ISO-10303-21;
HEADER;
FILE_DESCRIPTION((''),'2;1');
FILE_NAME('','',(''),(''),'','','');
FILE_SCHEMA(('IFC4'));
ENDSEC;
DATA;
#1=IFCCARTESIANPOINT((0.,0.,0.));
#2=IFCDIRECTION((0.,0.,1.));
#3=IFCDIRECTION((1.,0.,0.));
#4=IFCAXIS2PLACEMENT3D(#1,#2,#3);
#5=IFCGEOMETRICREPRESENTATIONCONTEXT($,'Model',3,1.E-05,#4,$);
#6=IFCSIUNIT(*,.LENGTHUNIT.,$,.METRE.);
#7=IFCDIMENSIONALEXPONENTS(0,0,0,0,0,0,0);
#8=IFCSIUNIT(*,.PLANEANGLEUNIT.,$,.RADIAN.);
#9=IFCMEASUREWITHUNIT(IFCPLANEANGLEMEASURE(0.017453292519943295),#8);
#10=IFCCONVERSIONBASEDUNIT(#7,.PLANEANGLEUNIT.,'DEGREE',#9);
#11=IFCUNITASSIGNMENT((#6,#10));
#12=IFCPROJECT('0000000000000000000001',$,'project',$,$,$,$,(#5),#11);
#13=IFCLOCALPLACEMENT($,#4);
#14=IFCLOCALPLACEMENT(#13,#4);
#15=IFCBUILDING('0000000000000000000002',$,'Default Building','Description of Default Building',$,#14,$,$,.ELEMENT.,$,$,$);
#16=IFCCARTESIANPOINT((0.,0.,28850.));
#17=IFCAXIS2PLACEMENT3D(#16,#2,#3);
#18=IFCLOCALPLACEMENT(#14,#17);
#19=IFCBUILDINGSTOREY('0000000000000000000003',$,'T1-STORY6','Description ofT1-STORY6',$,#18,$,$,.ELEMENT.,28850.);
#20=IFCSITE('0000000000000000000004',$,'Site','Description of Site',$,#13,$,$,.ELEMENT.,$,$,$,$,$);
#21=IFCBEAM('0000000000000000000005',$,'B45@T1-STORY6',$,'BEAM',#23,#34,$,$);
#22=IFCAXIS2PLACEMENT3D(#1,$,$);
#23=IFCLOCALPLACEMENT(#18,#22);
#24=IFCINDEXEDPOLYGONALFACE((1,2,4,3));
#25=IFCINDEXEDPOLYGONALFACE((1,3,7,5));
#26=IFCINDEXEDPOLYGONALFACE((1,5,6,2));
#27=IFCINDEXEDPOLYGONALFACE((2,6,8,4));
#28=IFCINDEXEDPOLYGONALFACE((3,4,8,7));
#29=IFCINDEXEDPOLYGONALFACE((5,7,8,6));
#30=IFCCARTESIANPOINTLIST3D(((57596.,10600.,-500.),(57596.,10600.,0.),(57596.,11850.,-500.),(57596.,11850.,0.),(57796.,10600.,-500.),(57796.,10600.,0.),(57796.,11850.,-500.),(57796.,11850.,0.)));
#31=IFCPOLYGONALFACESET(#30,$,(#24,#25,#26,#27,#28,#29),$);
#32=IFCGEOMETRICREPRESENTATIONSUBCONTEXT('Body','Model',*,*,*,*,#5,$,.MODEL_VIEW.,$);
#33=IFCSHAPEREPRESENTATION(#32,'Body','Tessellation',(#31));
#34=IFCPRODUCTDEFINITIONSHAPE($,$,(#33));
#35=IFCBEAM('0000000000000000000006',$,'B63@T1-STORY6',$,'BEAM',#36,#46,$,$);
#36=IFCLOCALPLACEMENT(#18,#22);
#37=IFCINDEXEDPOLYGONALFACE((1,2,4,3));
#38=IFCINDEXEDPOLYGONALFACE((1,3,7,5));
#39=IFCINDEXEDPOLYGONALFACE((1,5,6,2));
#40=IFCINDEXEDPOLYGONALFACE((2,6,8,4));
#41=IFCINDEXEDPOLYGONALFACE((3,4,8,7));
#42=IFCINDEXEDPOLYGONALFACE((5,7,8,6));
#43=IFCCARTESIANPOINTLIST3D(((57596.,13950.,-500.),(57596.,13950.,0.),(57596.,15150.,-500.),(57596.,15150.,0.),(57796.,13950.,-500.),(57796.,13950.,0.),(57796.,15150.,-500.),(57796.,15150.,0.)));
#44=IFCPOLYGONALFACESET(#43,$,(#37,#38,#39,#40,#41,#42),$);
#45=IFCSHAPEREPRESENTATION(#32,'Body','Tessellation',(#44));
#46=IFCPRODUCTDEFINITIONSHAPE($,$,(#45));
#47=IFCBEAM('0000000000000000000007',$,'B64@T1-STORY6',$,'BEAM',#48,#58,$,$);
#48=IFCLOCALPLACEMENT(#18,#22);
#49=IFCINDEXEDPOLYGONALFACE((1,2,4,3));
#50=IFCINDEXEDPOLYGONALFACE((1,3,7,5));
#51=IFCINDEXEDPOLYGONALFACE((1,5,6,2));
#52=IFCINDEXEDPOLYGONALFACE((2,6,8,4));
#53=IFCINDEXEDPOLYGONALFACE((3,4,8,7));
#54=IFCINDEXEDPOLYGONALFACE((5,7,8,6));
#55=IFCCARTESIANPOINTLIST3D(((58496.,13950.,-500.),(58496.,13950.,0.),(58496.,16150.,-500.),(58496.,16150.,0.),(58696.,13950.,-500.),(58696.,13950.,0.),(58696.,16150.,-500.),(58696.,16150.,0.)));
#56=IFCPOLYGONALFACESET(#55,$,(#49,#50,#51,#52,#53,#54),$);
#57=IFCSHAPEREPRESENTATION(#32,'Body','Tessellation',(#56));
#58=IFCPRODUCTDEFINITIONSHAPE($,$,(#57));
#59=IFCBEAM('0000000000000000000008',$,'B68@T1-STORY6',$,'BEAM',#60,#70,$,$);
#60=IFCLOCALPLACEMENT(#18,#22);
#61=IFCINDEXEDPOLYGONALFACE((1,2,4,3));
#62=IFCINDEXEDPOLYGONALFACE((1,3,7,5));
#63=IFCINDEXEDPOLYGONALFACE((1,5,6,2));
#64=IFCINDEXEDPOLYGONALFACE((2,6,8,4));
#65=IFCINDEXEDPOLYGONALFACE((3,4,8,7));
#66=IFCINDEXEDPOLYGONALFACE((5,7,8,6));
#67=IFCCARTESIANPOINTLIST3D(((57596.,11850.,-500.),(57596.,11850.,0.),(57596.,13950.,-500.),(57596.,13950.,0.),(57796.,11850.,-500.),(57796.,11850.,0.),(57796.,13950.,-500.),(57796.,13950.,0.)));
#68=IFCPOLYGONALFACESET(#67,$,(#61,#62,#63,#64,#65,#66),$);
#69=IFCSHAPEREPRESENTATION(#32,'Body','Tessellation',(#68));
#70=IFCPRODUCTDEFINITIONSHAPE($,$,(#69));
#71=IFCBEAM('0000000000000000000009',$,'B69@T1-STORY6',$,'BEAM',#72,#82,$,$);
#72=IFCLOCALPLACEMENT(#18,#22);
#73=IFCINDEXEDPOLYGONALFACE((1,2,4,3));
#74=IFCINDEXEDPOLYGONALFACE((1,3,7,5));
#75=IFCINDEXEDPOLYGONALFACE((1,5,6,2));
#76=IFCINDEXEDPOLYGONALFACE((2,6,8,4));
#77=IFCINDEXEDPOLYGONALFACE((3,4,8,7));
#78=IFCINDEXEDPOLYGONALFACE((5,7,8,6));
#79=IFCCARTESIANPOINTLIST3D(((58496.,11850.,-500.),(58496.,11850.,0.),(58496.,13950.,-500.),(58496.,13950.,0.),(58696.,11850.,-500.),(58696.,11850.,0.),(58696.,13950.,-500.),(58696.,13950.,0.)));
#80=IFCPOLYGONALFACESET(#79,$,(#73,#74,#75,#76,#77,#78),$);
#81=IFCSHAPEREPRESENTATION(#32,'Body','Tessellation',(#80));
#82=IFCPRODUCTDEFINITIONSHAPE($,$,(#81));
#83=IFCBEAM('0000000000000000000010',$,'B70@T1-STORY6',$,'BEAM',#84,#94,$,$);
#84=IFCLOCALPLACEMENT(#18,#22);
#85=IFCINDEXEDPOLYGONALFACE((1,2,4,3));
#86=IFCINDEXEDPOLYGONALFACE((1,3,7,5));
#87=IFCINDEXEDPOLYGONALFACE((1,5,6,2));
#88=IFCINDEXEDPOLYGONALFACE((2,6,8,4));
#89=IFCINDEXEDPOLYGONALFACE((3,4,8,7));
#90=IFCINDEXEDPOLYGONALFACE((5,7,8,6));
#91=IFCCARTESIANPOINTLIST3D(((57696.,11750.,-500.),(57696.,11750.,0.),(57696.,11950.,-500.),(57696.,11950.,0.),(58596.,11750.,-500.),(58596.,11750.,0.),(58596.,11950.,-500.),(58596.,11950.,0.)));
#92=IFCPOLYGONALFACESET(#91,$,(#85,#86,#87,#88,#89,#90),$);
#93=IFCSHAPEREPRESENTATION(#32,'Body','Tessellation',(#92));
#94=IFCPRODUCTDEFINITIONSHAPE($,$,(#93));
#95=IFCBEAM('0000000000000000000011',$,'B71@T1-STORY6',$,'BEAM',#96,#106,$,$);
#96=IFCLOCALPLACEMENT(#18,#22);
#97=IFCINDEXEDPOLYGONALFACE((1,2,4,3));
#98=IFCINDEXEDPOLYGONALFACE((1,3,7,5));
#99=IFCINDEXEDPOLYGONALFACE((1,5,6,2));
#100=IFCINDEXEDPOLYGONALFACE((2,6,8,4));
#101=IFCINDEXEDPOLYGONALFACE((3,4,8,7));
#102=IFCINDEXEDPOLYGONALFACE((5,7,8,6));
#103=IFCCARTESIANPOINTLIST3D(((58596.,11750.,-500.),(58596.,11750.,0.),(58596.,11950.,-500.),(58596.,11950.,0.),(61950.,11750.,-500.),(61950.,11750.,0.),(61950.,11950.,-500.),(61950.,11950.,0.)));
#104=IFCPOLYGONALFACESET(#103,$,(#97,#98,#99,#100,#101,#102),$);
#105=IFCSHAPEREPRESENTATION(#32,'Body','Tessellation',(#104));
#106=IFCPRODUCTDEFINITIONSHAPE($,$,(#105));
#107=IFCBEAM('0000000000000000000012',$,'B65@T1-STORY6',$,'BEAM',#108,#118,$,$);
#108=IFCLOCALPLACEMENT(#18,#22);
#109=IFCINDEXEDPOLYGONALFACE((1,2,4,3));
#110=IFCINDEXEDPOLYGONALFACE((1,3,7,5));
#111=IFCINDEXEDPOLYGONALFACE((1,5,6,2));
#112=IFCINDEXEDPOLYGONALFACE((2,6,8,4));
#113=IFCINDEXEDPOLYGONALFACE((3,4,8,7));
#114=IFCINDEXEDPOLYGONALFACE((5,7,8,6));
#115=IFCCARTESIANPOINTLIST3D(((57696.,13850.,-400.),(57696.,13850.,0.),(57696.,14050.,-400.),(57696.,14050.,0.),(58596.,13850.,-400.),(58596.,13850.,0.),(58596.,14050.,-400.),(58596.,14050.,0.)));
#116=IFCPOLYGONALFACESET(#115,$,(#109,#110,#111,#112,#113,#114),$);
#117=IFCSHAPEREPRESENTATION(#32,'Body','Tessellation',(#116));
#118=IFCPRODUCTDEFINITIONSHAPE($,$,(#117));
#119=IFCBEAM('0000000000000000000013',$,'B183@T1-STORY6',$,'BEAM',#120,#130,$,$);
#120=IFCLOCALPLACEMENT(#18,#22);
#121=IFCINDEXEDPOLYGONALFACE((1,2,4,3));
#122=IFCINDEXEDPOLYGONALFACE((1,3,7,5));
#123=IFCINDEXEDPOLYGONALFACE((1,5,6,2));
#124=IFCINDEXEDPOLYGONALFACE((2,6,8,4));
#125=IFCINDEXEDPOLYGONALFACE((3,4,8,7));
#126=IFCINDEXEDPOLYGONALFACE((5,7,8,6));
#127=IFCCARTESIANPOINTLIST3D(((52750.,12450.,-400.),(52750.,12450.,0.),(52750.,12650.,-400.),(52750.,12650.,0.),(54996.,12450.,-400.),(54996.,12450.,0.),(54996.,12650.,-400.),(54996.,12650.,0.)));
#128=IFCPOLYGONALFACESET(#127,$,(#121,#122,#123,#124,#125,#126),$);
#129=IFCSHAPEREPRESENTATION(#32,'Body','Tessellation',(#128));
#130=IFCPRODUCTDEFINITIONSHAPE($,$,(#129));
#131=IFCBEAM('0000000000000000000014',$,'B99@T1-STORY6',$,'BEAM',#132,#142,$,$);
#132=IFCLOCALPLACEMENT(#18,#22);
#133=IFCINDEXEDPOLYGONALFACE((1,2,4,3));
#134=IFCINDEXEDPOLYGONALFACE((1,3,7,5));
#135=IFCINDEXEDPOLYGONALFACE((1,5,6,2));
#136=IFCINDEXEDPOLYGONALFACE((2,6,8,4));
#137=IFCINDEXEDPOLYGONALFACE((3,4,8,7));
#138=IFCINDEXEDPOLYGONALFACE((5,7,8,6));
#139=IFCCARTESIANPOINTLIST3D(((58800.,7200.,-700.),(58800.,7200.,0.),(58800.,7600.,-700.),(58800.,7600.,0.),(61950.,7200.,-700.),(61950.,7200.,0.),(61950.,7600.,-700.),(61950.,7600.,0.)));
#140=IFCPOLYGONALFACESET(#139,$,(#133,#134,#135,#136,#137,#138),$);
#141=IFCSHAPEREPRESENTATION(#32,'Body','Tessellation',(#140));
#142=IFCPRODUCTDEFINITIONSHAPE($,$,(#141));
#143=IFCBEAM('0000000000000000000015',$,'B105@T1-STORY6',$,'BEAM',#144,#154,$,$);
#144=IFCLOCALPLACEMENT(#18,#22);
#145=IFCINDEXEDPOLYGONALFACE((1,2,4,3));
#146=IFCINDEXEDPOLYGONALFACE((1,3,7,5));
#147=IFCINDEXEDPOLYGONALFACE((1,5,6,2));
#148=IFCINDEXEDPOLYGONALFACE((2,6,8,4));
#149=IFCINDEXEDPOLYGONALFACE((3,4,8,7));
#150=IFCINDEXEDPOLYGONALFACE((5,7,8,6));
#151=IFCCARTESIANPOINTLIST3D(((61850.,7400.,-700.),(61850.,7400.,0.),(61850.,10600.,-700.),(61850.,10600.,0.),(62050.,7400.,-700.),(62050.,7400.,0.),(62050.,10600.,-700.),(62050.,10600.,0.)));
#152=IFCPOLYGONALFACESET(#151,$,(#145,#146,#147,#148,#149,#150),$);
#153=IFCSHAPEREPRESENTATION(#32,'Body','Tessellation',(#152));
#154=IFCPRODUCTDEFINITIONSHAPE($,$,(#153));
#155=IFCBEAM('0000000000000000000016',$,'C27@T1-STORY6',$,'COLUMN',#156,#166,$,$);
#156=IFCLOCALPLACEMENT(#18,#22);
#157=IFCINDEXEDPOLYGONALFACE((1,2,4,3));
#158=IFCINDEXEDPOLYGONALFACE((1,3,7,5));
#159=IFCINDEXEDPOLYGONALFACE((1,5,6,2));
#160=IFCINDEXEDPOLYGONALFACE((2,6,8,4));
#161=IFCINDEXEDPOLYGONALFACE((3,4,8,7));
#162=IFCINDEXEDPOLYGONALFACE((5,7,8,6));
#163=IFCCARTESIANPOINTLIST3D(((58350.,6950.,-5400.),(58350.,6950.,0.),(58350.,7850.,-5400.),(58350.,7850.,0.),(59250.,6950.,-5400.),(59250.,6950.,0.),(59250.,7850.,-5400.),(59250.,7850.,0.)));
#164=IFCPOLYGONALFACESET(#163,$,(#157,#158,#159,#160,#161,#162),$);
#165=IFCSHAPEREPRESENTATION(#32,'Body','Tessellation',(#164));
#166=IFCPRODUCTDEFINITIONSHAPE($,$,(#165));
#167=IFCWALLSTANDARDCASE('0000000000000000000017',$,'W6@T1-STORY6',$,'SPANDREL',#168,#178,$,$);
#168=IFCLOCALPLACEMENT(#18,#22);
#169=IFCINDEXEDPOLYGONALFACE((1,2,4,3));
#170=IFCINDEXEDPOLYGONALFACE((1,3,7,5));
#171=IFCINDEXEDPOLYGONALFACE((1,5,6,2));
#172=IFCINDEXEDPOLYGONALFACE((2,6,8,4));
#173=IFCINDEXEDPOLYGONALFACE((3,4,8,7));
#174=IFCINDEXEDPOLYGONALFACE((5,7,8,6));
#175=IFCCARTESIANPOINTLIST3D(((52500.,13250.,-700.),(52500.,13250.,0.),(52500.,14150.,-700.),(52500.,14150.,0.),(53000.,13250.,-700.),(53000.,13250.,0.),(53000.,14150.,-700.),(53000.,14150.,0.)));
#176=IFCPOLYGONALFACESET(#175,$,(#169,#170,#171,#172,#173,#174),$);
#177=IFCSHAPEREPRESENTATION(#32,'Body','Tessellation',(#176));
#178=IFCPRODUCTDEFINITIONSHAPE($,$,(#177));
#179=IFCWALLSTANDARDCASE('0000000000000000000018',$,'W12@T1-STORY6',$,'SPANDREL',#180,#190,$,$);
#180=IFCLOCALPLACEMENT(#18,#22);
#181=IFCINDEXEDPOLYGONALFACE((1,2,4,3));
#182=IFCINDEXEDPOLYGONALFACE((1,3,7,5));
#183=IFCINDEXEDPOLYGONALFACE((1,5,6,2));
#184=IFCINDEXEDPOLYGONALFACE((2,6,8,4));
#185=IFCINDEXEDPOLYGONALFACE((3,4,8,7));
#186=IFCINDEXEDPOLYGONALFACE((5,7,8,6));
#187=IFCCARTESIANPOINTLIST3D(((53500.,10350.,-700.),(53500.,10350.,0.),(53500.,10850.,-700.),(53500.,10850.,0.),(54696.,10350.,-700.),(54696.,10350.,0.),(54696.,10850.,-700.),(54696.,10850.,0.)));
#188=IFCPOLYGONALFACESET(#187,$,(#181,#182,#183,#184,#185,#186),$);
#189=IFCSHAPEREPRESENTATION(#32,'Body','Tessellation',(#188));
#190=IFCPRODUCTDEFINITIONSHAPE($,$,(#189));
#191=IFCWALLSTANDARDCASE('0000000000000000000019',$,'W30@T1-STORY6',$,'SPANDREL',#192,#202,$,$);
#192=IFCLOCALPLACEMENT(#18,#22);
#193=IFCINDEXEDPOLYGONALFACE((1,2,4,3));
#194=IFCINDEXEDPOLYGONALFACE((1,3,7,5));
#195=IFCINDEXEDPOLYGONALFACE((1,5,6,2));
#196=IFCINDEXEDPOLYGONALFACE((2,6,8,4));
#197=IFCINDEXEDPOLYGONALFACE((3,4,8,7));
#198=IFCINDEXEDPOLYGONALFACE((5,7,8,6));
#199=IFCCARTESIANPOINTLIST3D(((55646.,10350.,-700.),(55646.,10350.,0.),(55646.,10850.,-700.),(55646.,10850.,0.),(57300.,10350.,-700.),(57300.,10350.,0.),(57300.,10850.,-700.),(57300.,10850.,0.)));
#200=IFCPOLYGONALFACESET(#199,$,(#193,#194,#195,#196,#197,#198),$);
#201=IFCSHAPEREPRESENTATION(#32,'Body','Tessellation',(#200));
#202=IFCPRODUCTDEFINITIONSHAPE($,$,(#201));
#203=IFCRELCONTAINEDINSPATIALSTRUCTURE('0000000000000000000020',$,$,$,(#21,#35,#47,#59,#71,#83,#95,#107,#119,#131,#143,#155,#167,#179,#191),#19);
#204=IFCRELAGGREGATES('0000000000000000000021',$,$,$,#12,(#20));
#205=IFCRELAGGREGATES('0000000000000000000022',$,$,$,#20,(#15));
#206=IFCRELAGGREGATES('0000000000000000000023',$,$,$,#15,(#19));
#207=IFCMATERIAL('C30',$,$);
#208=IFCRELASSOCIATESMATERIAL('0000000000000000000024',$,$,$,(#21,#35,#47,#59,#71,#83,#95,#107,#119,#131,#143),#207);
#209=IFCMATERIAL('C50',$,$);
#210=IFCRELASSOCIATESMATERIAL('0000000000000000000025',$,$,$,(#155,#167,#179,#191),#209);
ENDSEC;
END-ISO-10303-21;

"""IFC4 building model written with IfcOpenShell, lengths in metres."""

from ifc_helpers import new_model, entity, si_unit, converted_unit, frame, origin_with_axes, place, context, subcontext, project, spatial, indexed_curve, rectangle, outline, extrude, material, element, save


model = new_model("IFC4")

# Units and contexts
model_context = context("Model", 3, precision=1e-05, world=origin_with_axes())
body_context = subcontext(model_context, "Body", "Model", "MODEL_VIEW")
ifc_project = project(units=[si_unit("LENGTHUNIT", "METRE"), converted_unit("PLANEANGLEUNIT", "DEGREE", entity("IfcPlaneAngleMeasure", 0.017453292519943295), si_unit("PLANEANGLEUNIT", "RADIAN"), dimensions=[0, 0, 0, 0, 0, 0, 0])], contexts=[model_context])

# Site, building, storey
site_placement = place(None, origin_with_axes())
site = spatial("IfcSite", under=ifc_project, at=site_placement, Name="Site", Description="Description of Site", CompositionType="ELEMENT")
building_placement = place(site_placement, origin_with_axes())
building = spatial("IfcBuilding", under=site, at=building_placement, Name="Default Building", Description="Description of Default Building", CompositionType="ELEMENT")
storey_placement = place(building_placement, frame((0.0, 0.0, 28850.0), z_axis=(0.0, 0.0, 1.0), x_axis=(1.0, 0.0, 0.0)))
storey = spatial("IfcBuildingStorey", under=building, at=storey_placement, Name="T1-STORY6", Description="Description ofT1-STORY6", CompositionType="ELEMENT", Elevation=28850.0)

# Beams
ifc_material_1 = material(Name="C30")
beam_1_placement = place(storey_placement, frame((57696.0, 10600.0, -250.0), z_axis=(0.0, 1.0, 0.0), x_axis=(-1.0, 0.0, 0.0)))
element("IfcBeam", 1, at=beam_1_placement, inside=storey, material=ifc_material_1, Name="B45@T1-STORY6", ObjectType="BEAM", context=body_context, shape_type="SweptSolid", body=[
    extrude(rectangle(XDim=200.0, YDim=500.0), origin_with_axes(), (0.0, 0.0, 1.0), 1250.0),
])
beam_2_placement = place(storey_placement, frame((57696.0, 13950.0, -250.0), z_axis=(0.0, 1.0, 0.0), x_axis=(-1.0, 0.0, 0.0)))
element("IfcBeam", 2, at=beam_2_placement, inside=storey, material=ifc_material_1, Name="B63@T1-STORY6", ObjectType="BEAM", context=body_context, shape_type="SweptSolid", body=[
    extrude(rectangle(XDim=200.0, YDim=500.0), origin_with_axes(), (0.0, 0.0, 1.0), 1200.0),
])
beam_3_placement = place(storey_placement, frame((58596.0, 13950.0, -250.0), z_axis=(0.0, 1.0, 0.0), x_axis=(-1.0, 0.0, 0.0)))
element("IfcBeam", 3, at=beam_3_placement, inside=storey, material=ifc_material_1, Name="B64@T1-STORY6", ObjectType="BEAM", context=body_context, shape_type="SweptSolid", body=[
    extrude(rectangle(XDim=200.0, YDim=500.0), origin_with_axes(), (0.0, 0.0, 1.0), 2200.0),
])
for number, where, z_axis, x_axis, name in (
    (4, (57696.0, 11850.0, -250.0), (0.0, 1.0, 0.0), (-1.0, 0.0, 0.0), "B68@T1-STORY6"),
    (5, (58596.0, 11850.0, -250.0), (0.0, 1.0, 0.0), (-1.0, 0.0, 0.0), "B69@T1-STORY6"),
):
    element("IfcBeam", number, at=place(storey_placement, frame(where, z_axis=z_axis, x_axis=x_axis)), inside=storey, material=ifc_material_1, Name=name, ObjectType="BEAM", context=body_context, shape_type="SweptSolid", body=[
        extrude(rectangle(XDim=200.0, YDim=500.0), origin_with_axes(), (0.0, 0.0, 1.0), 2100.0),
    ])
beam_4_placement = place(storey_placement, frame((57696.0, 11850.0, -250.0), z_axis=(1.0, 0.0, 0.0), x_axis=(0.0, 1.0, 0.0)))
element("IfcBeam", 6, at=beam_4_placement, inside=storey, material=ifc_material_1, Name="B70@T1-STORY6", ObjectType="BEAM", context=body_context, shape_type="SweptSolid", body=[
    extrude(rectangle(XDim=200.0, YDim=500.0), origin_with_axes(), (0.0, 0.0, 1.0), 900.0),
])
beam_5_placement = place(storey_placement, frame((58596.0, 11850.0, -250.0), z_axis=(1.0, 0.0, 0.0), x_axis=(0.0, 1.0, 0.0)))
element("IfcBeam", 7, at=beam_5_placement, inside=storey, material=ifc_material_1, Name="B71@T1-STORY6", ObjectType="BEAM", context=body_context, shape_type="SweptSolid", body=[
    extrude(rectangle(XDim=200.0, YDim=500.0), origin_with_axes(), (0.0, 0.0, 1.0), 3354.0),
])
beam_6_placement = place(storey_placement, frame((57696.0, 13950.0, -200.0), z_axis=(1.0, 0.0, 0.0), x_axis=(0.0, 1.0, 0.0)))
element("IfcBeam", 8, at=beam_6_placement, inside=storey, material=ifc_material_1, Name="B65@T1-STORY6", ObjectType="BEAM", context=body_context, shape_type="SweptSolid", body=[
    extrude(rectangle(XDim=200.0, YDim=400.0), origin_with_axes(), (0.0, 0.0, 1.0), 900.0),
])
beam_7_placement = place(storey_placement, frame((52750.0, 12550.0, -200.0), z_axis=(1.0, 0.0, 0.0), x_axis=(0.0, 1.0, 0.0)))
element("IfcBeam", 9, at=beam_7_placement, inside=storey, material=ifc_material_1, Name="B183@T1-STORY6", ObjectType="BEAM", context=body_context, shape_type="SweptSolid", body=[
    extrude(rectangle(XDim=200.0, YDim=400.0), origin_with_axes(), (0.0, 0.0, 1.0), 2246.0),
])
beam_8_placement = place(storey_placement, frame((58800.0, 7400.0, -350.0), z_axis=(1.0, 0.0, 0.0), x_axis=(0.0, 1.0, 0.0)))
element("IfcBeam", 10, at=beam_8_placement, inside=storey, material=ifc_material_1, Name="B99@T1-STORY6", ObjectType="BEAM", context=body_context, shape_type="SweptSolid", body=[
    extrude(rectangle(XDim=400.0, YDim=700.0), origin_with_axes(), (0.0, 0.0, 1.0), 3150.0),
])
beam_9_placement = place(storey_placement, frame((61950.0, 7400.0, -350.0), z_axis=(0.0, 1.0, 0.0), x_axis=(-1.0, 0.0, 0.0)))
element("IfcBeam", 11, at=beam_9_placement, inside=storey, material=ifc_material_1, Name="B105@T1-STORY6", ObjectType="BEAM", context=body_context, shape_type="SweptSolid", body=[
    extrude(rectangle(XDim=200.0, YDim=700.0), origin_with_axes(), (0.0, 0.0, 1.0), 3200.0),
])
ifc_material_2 = material(Name="C50")
beam_10_placement = place(storey_placement, frame((58800.0, 7400.0, -5400.0), z_axis=(0.0, 0.0, 1.0), x_axis=(-1.0, 0.0, 0.0)))
element("IfcBeam", 12, at=beam_10_placement, inside=storey, material=ifc_material_2, Name="C27@T1-STORY6", ObjectType="COLUMN", context=body_context, shape_type="SweptSolid", body=[
    extrude(rectangle(XDim=900.0, YDim=900.0), origin_with_axes(), (0.0, 0.0, 1.0), 5400.0),
])

# Walls
wall_1_placement = place(storey_placement, frame((52750.0, 13250.0, -700.0), z_axis=(0.0, 0.0, 1.0), x_axis=(0.0, 1.0, 0.0)))
element("IfcWallStandardCase", 13, at=wall_1_placement, inside=storey, material=ifc_material_2, Name="W6@T1-STORY6", ObjectType="SPANDREL", context=body_context, shape_type="SweptSolid", body=[
    extrude(outline(indexed_curve([(0.0, -250.0), (0.0, 250.0), (900.0, 250.0), (900.0, -250.0), (0.0, -250.0)], self_intersect=False)), origin_with_axes(), (0.0, 0.0, 1.0), 700.0),
])
wall_2_placement = place(storey_placement, frame((53500.0, 10600.0, -700.0), z_axis=(0.0, 0.0, 1.0), x_axis=(1.0, 0.0, 0.0)))
element("IfcWallStandardCase", 14, at=wall_2_placement, inside=storey, material=ifc_material_2, Name="W12@T1-STORY6", ObjectType="SPANDREL", context=body_context, shape_type="SweptSolid", body=[
    extrude(outline(indexed_curve([(0.0, -250.0), (0.0, 250.0), (1196.0, 250.0), (1196.0, -250.0), (0.0, -250.0)], self_intersect=False)), origin_with_axes(), (0.0, 0.0, 1.0), 700.0),
])
wall_3_placement = place(storey_placement, frame((55646.0, 10600.0, -700.0), z_axis=(0.0, 0.0, 1.0), x_axis=(1.0, 0.0, 0.0)))
element("IfcWallStandardCase", 15, at=wall_3_placement, inside=storey, material=ifc_material_2, Name="W30@T1-STORY6", ObjectType="SPANDREL", context=body_context, shape_type="SweptSolid", body=[
    extrude(outline(indexed_curve([(0.0, -250.0), (0.0, 250.0), (1654.0, 250.0), (1654.0, -250.0), (0.0, -250.0)], self_intersect=False)), origin_with_axes(), (0.0, 0.0, 1.0), 700.0),
])

save(model, "model.ifc")
